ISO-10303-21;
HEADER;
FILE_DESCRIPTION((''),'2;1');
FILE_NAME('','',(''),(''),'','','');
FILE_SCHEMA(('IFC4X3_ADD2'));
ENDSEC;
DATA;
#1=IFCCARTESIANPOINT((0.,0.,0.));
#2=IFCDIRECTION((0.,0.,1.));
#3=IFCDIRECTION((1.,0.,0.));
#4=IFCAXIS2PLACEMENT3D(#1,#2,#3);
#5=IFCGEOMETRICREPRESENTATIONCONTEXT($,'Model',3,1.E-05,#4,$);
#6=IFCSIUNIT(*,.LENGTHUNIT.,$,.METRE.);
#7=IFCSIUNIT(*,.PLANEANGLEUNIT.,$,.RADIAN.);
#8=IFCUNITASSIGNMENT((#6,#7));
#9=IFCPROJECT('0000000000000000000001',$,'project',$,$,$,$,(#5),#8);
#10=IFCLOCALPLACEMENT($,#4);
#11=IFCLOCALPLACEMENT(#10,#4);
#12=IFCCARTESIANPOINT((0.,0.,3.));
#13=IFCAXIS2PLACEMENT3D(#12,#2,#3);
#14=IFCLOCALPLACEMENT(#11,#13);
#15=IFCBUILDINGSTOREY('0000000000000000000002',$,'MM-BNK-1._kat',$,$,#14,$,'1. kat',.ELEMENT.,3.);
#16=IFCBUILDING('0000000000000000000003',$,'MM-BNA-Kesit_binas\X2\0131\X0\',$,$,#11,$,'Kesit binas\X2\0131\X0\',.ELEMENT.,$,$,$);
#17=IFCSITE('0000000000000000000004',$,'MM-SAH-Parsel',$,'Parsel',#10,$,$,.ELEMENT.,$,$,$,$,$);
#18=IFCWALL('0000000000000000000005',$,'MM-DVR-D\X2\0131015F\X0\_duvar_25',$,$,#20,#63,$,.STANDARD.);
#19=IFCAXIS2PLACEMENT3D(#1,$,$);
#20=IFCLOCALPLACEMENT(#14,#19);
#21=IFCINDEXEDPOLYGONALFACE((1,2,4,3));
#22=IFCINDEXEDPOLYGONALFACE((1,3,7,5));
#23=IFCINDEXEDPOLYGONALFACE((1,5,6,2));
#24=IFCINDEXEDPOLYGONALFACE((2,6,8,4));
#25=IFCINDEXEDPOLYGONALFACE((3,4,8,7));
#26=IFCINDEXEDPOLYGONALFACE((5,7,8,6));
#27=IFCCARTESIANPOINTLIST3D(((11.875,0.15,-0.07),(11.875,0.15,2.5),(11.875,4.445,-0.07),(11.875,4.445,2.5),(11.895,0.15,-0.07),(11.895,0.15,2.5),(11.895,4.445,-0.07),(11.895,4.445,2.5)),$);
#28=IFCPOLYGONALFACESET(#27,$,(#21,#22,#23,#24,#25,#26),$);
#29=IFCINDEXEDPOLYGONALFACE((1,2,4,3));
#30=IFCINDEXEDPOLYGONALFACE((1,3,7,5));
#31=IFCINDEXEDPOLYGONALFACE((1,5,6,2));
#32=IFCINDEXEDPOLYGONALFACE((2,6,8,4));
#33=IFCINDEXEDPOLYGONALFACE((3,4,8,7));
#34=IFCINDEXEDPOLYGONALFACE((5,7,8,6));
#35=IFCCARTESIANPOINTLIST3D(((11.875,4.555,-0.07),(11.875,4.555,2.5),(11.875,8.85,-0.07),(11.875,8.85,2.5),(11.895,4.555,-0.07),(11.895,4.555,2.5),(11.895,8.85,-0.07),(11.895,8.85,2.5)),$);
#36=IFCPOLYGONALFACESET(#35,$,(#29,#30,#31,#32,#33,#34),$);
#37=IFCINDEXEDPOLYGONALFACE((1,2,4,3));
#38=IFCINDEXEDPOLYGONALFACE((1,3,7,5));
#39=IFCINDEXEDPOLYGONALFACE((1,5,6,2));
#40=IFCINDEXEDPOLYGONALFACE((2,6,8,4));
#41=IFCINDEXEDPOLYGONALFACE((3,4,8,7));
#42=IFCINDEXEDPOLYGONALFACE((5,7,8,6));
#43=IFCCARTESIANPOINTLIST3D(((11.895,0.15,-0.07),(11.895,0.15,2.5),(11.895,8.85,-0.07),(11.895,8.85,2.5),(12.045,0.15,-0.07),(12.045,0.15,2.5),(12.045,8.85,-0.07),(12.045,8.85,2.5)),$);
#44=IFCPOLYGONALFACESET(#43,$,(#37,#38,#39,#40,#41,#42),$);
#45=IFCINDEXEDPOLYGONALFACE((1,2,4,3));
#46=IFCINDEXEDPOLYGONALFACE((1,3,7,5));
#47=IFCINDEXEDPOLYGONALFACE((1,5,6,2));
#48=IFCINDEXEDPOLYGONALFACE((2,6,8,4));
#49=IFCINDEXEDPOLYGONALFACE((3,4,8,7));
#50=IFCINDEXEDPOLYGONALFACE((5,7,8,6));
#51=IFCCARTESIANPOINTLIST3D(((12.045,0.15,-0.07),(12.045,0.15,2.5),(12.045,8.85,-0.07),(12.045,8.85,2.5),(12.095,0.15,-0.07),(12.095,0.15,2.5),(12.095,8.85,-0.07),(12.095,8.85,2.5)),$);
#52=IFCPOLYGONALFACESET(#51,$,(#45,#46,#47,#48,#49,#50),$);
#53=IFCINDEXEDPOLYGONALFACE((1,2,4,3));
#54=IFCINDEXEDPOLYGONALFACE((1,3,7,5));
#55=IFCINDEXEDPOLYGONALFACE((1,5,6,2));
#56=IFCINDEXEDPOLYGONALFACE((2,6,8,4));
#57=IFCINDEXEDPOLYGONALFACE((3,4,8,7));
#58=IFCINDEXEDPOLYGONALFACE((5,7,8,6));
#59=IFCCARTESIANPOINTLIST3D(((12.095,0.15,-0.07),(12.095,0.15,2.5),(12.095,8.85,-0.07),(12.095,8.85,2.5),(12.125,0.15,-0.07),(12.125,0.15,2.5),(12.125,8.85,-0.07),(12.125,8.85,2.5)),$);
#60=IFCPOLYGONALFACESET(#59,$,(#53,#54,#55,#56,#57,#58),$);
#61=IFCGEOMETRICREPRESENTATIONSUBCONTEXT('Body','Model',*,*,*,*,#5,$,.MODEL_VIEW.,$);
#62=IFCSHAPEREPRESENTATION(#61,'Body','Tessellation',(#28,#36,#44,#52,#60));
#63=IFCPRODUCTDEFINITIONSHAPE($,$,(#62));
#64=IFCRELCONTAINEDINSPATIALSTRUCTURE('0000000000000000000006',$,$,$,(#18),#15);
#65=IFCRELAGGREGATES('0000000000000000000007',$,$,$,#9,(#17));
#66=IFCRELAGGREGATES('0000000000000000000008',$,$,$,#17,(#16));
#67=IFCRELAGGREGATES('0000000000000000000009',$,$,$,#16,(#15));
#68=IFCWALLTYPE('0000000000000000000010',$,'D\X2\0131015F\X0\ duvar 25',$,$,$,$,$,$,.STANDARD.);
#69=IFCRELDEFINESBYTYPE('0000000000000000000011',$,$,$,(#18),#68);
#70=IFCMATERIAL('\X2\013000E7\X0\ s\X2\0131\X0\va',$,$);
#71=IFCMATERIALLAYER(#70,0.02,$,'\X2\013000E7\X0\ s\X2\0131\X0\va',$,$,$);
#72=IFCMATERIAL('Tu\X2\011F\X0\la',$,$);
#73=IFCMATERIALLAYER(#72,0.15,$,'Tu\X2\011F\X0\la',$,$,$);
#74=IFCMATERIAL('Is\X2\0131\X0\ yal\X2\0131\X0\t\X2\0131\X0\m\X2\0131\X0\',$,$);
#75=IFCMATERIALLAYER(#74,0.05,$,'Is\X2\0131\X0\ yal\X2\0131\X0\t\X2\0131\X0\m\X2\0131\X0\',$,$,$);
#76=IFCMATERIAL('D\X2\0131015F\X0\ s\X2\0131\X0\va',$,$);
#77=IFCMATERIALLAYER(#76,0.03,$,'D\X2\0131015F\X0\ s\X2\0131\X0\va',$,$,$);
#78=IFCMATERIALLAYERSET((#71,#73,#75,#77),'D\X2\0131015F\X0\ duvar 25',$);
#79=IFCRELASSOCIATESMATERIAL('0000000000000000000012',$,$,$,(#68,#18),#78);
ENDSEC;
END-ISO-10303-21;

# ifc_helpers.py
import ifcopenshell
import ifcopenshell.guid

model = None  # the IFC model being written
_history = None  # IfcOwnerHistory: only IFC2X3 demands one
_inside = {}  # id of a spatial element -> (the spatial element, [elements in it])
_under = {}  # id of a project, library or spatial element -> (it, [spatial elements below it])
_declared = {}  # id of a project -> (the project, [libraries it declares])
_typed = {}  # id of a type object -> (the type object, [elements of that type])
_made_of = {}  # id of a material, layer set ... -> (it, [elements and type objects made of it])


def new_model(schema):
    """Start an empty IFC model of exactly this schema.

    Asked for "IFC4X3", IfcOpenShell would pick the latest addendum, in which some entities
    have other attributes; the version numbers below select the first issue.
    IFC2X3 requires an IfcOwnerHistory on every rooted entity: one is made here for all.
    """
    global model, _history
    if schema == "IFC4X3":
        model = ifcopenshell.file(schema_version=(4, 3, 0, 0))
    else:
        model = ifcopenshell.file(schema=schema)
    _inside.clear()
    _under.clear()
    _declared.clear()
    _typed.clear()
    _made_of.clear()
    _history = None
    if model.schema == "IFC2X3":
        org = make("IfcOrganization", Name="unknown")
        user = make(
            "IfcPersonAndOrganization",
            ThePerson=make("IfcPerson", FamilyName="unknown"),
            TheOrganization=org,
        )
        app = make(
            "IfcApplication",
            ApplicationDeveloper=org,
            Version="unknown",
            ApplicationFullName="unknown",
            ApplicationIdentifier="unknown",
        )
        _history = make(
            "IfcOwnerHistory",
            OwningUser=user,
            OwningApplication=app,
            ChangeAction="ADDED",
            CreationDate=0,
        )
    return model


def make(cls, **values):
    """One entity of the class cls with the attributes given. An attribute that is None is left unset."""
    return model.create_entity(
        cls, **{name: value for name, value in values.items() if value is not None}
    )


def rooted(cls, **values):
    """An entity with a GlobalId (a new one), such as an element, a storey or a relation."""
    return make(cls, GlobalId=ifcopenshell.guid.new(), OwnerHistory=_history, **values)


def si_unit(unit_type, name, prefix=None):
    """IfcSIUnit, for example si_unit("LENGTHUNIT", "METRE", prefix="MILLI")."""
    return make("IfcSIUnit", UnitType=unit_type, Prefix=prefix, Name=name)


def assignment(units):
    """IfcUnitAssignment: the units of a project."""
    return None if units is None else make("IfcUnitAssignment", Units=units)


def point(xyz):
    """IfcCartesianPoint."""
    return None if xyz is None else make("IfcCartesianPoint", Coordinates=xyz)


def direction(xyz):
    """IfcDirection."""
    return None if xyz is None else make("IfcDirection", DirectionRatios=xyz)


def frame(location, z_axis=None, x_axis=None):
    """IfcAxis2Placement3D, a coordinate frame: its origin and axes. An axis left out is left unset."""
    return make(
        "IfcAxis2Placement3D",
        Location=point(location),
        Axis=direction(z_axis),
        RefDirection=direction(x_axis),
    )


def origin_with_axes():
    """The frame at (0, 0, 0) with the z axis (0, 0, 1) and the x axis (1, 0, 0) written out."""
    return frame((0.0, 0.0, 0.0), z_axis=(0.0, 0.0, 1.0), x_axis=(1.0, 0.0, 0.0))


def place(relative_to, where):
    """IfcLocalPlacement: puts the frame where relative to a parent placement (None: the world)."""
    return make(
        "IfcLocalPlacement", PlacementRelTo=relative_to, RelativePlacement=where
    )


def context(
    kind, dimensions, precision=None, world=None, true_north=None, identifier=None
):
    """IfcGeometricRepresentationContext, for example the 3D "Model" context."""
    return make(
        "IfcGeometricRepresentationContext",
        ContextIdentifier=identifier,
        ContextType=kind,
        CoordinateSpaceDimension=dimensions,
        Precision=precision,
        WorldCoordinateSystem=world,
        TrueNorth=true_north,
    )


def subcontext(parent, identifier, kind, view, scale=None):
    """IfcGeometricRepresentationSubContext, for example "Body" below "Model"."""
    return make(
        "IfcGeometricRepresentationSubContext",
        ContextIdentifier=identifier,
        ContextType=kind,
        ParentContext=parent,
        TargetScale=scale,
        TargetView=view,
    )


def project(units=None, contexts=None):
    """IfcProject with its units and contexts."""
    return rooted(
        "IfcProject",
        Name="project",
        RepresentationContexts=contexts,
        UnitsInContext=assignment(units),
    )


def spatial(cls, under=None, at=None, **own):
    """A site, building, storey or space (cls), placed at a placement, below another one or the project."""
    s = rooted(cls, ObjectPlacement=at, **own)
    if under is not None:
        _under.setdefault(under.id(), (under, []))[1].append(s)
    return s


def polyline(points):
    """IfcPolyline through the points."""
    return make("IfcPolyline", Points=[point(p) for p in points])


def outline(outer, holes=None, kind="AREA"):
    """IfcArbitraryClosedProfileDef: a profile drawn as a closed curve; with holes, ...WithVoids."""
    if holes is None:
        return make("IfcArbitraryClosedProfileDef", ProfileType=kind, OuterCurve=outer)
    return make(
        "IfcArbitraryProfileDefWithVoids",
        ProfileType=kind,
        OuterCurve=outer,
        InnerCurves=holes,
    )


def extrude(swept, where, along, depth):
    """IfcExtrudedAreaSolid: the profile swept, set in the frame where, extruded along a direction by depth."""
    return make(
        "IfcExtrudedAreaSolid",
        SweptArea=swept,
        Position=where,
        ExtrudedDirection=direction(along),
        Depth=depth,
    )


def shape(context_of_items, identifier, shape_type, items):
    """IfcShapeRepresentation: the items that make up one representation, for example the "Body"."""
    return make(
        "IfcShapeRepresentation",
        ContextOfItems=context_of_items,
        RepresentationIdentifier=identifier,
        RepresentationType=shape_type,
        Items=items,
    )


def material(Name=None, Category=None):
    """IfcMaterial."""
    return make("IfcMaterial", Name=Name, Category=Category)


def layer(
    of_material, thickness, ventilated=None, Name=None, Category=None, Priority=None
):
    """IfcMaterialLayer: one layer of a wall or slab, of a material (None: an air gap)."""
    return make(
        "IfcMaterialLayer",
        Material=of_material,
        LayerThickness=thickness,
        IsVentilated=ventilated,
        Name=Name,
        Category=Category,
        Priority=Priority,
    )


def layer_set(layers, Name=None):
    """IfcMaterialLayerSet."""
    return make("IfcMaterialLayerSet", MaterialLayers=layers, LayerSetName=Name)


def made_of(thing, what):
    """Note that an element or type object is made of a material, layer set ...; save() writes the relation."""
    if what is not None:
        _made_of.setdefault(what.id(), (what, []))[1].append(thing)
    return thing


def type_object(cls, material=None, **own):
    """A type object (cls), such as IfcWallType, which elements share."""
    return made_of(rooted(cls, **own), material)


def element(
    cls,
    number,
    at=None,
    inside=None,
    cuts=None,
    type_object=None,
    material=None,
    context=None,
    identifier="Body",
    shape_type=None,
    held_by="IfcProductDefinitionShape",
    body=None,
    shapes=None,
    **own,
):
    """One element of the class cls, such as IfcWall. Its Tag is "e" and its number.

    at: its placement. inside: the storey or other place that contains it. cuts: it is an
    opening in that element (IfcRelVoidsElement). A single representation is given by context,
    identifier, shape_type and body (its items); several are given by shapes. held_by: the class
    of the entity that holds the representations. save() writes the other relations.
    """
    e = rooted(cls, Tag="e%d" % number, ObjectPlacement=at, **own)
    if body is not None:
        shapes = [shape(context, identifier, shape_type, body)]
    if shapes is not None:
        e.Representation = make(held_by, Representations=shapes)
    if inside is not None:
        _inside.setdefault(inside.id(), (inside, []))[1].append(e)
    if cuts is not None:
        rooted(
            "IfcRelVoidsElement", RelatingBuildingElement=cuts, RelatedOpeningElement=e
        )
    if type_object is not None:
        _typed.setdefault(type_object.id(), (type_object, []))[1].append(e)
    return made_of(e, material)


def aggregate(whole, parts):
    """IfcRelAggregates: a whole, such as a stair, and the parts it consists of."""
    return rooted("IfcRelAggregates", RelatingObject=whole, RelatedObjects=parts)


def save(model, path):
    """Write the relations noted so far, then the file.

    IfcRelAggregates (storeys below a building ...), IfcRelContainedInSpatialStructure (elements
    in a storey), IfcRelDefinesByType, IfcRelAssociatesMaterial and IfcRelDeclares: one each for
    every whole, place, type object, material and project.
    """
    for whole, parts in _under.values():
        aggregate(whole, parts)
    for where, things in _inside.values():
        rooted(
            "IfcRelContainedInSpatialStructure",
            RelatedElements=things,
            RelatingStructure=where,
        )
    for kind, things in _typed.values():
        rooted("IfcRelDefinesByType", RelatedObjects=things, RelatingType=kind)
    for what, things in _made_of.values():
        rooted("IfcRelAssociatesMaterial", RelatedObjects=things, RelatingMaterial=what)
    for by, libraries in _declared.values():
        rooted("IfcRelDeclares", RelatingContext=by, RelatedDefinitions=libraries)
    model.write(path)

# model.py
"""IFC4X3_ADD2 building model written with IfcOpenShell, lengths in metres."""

from ifc_helpers import new_model, si_unit, frame, origin_with_axes, place, context, subcontext, project, spatial, polyline, outline, extrude, material, layer, layer_set, type_object, element, save


model = new_model("IFC4X3_ADD2")

# Units and contexts
model_context = context("Model", 3, precision=1e-05, world=origin_with_axes())
body_context = subcontext(model_context, "Body", "Model", "MODEL_VIEW")
ifc_project = project(units=[si_unit("LENGTHUNIT", "METRE"), si_unit("PLANEANGLEUNIT", "RADIAN")], contexts=[model_context])

# Site, building, storey
site_placement = place(None, origin_with_axes())
site = spatial("IfcSite", under=ifc_project, at=site_placement, Name="MM-SAH-Parsel", ObjectType="Parsel", CompositionType="ELEMENT")
building_placement = place(site_placement, origin_with_axes())
building = spatial("IfcBuilding", under=site, at=building_placement, Name="MM-BNA-Kesit_binası", LongName="Kesit binası", CompositionType="ELEMENT")
storey_placement = place(building_placement, frame((0.0, 0.0, 3.0), z_axis=(0.0, 0.0, 1.0), x_axis=(1.0, 0.0, 0.0)))
storey = spatial("IfcBuildingStorey", under=building, at=storey_placement, Name="MM-BNK-1._kat", LongName="1. kat", CompositionType="ELEMENT", Elevation=3.0)

# Shared definitions
ifc_material_1 = material(Name="İç sıva")
ifc_layer_1 = layer(ifc_material_1, 0.02, Name="İç sıva")
ifc_material_2 = material(Name="Tuğla")
ifc_layer_2 = layer(ifc_material_2, 0.15, Name="Tuğla")
ifc_material_3 = material(Name="Isı yalıtımı")
ifc_layer_3 = layer(ifc_material_3, 0.05, Name="Isı yalıtımı")
ifc_material_4 = material(Name="Dış sıva")
ifc_layer_4 = layer(ifc_material_4, 0.03, Name="Dış sıva")
ifc_layer_set_1 = layer_set([ifc_layer_1, ifc_layer_2, ifc_layer_3, ifc_layer_4], Name="Dış duvar 25")
wall_type_1 = type_object("IfcWallType", Name="Dış duvar 25", PredefinedType="STANDARD", material=ifc_layer_set_1)

# Wall
wall_1_placement = place(storey_placement, origin_with_axes())
element("IfcWall", 1, at=wall_1_placement, inside=storey, type_object=wall_type_1, material=ifc_layer_set_1, Name="MM-DVR-Dış_duvar_25", PredefinedType="STANDARD", context=body_context, shape_type="SweptSolid", body=[
    extrude(outline(polyline([(11.895, 0.15), (11.895, 4.445), (11.875, 4.445), (11.875, 0.15), (11.895, 0.15)])), frame((0.0, 0.0, -0.07)), (0.0, 0.0, 1.0), 2.57),
    extrude(outline(polyline([(11.895, 4.555), (11.895, 8.85), (11.875, 8.85), (11.875, 4.555), (11.895, 4.555)])), frame((0.0, 0.0, -0.07)), (0.0, 0.0, 1.0), 2.57),
    extrude(outline(polyline([(12.045, 0.15), (12.045, 8.85), (11.895, 8.85), (11.895, 0.15), (12.045, 0.15)])), frame((0.0, 0.0, -0.07)), (0.0, 0.0, 1.0), 2.57),
    extrude(outline(polyline([(12.095, 0.15), (12.095, 8.85), (12.045, 8.85), (12.045, 0.15), (12.095, 0.15)])), frame((0.0, 0.0, -0.07)), (0.0, 0.0, 1.0), 2.57),
    extrude(outline(polyline([(12.125, 0.15), (12.125, 8.85), (12.095, 8.85), (12.095, 0.15), (12.125, 0.15)])), frame((0.0, 0.0, -0.07)), (0.0, 0.0, 1.0), 2.57),
])

save(model, "model.ifc")
